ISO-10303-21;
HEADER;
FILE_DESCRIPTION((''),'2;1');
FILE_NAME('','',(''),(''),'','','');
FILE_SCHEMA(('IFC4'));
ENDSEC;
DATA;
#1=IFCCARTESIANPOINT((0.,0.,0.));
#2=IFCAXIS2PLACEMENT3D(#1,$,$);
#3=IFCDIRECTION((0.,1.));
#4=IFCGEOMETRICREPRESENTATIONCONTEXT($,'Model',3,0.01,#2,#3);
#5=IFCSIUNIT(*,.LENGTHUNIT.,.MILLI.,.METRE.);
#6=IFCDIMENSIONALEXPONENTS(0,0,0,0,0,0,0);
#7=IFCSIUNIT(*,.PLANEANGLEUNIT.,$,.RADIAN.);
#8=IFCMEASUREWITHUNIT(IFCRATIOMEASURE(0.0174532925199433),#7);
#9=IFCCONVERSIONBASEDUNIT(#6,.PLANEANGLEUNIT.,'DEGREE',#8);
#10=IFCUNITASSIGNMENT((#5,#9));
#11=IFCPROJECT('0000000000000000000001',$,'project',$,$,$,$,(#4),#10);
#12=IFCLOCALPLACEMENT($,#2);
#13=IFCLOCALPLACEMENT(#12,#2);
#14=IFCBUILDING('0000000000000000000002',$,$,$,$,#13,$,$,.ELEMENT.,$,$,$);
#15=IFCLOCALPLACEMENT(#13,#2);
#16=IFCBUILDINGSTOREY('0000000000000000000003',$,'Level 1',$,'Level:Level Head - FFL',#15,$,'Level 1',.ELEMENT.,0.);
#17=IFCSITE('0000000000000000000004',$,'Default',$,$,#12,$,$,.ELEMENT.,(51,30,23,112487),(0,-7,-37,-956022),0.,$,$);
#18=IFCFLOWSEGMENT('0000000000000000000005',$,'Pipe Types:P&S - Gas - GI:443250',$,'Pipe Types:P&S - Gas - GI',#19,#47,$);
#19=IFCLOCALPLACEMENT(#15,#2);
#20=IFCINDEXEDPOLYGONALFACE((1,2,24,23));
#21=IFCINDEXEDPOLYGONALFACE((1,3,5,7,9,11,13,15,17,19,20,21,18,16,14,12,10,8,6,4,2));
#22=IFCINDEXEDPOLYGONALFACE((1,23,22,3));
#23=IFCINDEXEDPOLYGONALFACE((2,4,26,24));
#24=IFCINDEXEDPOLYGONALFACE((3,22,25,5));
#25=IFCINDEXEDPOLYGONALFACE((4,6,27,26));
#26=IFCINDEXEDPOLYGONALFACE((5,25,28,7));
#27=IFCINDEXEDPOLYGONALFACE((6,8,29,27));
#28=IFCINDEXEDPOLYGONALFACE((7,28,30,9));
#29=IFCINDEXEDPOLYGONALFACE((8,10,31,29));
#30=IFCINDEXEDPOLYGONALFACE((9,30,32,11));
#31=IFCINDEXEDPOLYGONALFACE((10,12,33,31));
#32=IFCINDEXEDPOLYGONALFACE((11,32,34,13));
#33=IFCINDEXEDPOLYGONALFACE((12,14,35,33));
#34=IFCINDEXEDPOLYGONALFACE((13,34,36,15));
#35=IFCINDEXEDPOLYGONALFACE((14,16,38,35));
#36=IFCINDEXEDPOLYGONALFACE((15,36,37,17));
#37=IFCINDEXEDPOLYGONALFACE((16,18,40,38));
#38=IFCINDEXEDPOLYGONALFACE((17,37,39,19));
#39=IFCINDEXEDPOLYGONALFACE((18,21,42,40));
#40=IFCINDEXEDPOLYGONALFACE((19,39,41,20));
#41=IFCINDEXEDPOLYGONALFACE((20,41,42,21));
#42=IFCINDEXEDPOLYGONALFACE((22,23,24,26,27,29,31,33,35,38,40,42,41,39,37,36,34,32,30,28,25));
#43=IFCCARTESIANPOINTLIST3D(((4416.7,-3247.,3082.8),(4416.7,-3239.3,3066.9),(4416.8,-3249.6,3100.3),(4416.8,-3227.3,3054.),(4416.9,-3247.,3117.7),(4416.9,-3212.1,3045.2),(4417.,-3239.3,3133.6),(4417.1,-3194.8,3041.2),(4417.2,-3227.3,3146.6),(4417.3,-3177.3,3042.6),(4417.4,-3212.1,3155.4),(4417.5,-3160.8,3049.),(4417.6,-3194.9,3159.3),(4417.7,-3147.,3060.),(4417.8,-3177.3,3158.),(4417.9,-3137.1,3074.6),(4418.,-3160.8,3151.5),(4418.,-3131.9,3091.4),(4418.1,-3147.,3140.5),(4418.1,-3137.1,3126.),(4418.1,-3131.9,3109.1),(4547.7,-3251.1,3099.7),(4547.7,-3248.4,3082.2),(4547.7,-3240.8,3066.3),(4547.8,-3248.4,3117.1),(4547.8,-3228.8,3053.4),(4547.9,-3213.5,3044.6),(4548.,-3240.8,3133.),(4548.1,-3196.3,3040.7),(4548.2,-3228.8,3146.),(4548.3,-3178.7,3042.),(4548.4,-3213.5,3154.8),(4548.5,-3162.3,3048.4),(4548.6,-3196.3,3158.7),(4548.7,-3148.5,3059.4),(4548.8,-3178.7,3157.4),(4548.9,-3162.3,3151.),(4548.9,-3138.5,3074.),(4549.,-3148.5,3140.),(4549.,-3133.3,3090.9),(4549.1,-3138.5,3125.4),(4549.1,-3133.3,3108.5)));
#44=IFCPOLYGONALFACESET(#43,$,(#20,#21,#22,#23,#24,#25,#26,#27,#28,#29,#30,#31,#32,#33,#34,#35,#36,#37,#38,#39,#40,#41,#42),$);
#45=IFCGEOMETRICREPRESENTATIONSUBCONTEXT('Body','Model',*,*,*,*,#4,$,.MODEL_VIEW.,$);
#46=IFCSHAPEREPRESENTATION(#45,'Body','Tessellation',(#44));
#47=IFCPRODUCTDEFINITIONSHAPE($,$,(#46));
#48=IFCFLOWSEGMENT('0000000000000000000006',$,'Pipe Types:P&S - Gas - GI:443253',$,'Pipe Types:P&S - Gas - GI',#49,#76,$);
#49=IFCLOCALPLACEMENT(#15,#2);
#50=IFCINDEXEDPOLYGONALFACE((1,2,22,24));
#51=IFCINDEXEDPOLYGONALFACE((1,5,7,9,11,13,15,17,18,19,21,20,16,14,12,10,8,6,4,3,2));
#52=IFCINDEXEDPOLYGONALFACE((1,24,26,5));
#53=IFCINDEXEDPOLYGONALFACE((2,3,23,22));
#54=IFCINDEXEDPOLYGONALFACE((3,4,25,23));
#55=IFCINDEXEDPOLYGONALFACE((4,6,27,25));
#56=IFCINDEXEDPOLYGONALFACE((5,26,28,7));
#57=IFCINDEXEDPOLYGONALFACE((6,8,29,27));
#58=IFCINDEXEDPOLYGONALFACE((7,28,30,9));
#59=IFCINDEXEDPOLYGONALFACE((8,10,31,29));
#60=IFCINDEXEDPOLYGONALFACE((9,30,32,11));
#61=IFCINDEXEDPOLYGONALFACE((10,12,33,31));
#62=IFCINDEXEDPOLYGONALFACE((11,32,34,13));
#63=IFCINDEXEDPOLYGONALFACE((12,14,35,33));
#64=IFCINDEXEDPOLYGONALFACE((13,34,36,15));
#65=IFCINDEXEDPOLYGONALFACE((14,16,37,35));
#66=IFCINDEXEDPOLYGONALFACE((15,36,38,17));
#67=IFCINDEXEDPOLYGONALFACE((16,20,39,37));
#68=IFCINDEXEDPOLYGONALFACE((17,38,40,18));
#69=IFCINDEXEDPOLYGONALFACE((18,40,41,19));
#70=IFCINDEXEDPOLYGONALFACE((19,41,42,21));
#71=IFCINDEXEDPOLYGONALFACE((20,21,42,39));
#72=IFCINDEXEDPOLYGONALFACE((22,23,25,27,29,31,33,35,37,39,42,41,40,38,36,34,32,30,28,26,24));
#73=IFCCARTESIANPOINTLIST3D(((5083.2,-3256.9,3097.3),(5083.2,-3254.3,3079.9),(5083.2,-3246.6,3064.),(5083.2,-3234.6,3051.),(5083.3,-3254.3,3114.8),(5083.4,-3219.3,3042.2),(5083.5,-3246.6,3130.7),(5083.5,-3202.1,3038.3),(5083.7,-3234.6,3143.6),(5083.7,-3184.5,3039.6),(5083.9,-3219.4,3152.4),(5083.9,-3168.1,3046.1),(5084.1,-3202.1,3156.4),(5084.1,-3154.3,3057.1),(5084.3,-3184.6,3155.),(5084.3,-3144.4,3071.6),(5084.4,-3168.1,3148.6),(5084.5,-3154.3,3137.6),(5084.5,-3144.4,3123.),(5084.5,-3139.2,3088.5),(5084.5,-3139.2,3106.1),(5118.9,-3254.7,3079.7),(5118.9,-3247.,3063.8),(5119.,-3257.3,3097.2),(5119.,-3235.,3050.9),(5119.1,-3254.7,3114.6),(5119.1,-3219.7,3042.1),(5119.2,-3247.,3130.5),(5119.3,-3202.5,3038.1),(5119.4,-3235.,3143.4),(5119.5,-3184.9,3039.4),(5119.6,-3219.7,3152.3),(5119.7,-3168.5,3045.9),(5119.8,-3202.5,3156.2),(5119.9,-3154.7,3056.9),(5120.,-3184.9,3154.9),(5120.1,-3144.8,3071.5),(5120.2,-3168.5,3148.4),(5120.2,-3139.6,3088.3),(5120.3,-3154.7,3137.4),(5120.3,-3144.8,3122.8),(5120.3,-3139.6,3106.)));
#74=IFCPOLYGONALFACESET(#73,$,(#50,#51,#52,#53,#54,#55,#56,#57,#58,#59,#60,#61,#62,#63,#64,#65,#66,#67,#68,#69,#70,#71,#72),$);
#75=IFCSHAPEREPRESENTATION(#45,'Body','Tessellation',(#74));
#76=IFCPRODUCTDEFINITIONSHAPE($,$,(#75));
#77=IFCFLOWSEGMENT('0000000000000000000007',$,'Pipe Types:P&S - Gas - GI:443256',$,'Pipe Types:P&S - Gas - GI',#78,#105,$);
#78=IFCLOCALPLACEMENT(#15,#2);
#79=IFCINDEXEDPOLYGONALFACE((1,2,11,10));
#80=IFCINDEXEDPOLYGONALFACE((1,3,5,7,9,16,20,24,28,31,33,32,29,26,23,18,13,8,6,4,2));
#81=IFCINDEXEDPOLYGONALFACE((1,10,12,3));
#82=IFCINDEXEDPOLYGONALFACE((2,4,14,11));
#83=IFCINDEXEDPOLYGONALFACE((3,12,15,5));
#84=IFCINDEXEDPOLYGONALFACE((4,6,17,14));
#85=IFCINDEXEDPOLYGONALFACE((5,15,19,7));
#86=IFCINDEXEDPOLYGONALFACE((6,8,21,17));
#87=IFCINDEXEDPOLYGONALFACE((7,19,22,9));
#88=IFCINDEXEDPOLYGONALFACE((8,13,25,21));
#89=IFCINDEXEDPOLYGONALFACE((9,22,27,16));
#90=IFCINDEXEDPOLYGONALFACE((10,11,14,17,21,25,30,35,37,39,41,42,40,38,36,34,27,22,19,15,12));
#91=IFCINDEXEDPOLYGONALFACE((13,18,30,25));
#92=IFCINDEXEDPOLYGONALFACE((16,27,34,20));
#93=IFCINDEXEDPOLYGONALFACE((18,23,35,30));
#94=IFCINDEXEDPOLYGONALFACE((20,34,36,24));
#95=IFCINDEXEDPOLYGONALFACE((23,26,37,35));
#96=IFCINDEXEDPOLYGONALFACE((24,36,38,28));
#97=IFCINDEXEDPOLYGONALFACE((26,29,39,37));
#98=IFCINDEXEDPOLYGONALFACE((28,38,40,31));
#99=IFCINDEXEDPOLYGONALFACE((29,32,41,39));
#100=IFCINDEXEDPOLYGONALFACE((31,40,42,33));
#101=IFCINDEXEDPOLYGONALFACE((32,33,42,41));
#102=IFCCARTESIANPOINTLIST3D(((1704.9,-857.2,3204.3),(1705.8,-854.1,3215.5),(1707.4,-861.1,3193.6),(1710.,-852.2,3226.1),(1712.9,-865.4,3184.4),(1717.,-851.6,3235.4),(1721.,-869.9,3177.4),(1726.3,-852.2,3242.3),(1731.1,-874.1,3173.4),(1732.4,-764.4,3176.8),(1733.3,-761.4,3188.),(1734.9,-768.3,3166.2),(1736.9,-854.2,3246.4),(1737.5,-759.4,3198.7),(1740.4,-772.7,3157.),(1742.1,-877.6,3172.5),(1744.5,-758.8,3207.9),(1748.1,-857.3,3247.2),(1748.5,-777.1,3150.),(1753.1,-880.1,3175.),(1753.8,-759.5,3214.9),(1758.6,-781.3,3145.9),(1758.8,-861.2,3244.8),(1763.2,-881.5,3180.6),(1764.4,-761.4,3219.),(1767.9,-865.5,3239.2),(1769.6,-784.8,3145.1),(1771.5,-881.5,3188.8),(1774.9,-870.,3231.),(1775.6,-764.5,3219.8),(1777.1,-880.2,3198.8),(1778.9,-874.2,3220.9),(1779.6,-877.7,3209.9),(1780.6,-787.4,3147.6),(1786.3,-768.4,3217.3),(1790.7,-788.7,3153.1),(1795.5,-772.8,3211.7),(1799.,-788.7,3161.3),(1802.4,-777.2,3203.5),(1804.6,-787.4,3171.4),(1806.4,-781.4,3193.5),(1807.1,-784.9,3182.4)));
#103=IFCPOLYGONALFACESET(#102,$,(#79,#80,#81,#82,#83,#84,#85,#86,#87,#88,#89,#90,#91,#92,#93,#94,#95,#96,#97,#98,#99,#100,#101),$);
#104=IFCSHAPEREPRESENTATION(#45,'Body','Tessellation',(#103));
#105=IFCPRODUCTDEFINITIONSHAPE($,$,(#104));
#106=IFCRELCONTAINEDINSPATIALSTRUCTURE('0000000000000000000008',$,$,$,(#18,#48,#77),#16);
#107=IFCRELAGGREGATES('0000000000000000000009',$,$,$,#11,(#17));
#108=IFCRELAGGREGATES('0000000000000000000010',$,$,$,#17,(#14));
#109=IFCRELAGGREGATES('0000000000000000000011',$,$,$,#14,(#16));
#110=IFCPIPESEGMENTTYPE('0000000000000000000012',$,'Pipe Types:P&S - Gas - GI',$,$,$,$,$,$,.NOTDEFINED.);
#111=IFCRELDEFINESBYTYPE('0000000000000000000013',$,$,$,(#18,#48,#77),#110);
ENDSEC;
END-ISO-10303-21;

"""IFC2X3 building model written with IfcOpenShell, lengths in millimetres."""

from ifc_helpers import new_model, entity, si_unit, converted_unit, direction, frame, frame_2d, origin, origin_2d_with_axis, place, context, subcontext, project, spatial, circle, extrude, type_object, element, save


model = new_model("IFC2X3")

# Units and contexts
model_context = context("Model", 3, precision=0.01, world=origin(), true_north=direction((0.0, 1.0)))
body_context = subcontext(model_context, "Body", "Model", "MODEL_VIEW")
ifc_project = project(units=[si_unit("LENGTHUNIT", "METRE", prefix="MILLI"), converted_unit("PLANEANGLEUNIT", "DEGREE", entity("IfcRatioMeasure", 0.0174532925199433), si_unit("PLANEANGLEUNIT", "RADIAN"), dimensions=[0, 0, 0, 0, 0, 0, 0])], contexts=[model_context])

# Site, building, storey
site_placement = place(None, origin())
site = spatial("IfcSite", under=ifc_project, at=site_placement, Name="Default", CompositionType="ELEMENT", RefLatitude=(51, 30, 23, 112487), RefLongitude=(0, -7, -37, -956022), RefElevation=0.0)
building_placement = place(site_placement, origin())
building = spatial("IfcBuilding", under=site, at=building_placement, CompositionType="ELEMENT")
storey_placement = place(building_placement, origin())
storey = spatial("IfcBuildingStorey", under=building, at=storey_placement, Name="Level 1", ObjectType="Level:Level Head - FFL", LongName="Level 1", CompositionType="ELEMENT", Elevation=0.0)

# Flow segments
pipe_segment_type = type_object("IfcPipeSegmentType", Name="Pipe Types:P&S - Gas - GI", PredefinedType="NOTDEFINED")
flow_segment_1_placement = place(storey_placement, origin())
element("IfcFlowSegment", 1, at=flow_segment_1_placement, inside=storey, type_object=pipe_segment_type, Name="Pipe Types:P&S - Gas - GI:443250", ObjectType="Pipe Types:P&S - Gas - GI", context=body_context, shape_type="SweptSolid", body=[
    extrude(circle(Radius=59.2, at=frame_2d((0.0, 0.0), x_axis=(1.0, 0.0))), frame((4417.4, -3190.4, 3100.3), z_axis=(0.99993, -0.010942, -0.004424), x_axis=(-0.010943, -0.99994, 0.0)), (0.0, 0.0, 1.0), 131.0),
])
flow_segment_2_placement = place(storey_placement, origin())
element("IfcFlowSegment", 2, at=flow_segment_2_placement, inside=storey, type_object=pipe_segment_type, Name="Pipe Types:P&S - Gas - GI:443253", ObjectType="Pipe Types:P&S - Gas - GI", context=body_context, shape_type="SweptSolid", body=[
    extrude(circle(Radius=59.2, at=origin_2d_with_axis()), frame((5083.9, -3197.7, 3097.3), z_axis=(0.99993, -0.010942, -0.004424), x_axis=(-0.010943, -0.99994, 0.0)), (0.0, 0.0, 1.0), 35.8),
])
flow_segment_3_placement = place(storey_placement, origin())
element("IfcFlowSegment", 3, at=flow_segment_3_placement, inside=storey, type_object=pipe_segment_type, Name="Pipe Types:P&S - Gas - GI:443256", ObjectType="Pipe Types:P&S - Gas - GI", context=body_context, shape_type="SweptSolid", body=[
    extrude(circle(Radius=38.9, at=frame_2d((0.0, 0.0), x_axis=(1.0, 0.0))), frame((1742.3, -866.6, 3209.9), z_axis=(0.273456, 0.922363, -0.272889), x_axis=(0.958752, -0.284245, 0.0)), (0.0, 0.0, 1.0), 100.6),
])

save(model, "model.ifc")
